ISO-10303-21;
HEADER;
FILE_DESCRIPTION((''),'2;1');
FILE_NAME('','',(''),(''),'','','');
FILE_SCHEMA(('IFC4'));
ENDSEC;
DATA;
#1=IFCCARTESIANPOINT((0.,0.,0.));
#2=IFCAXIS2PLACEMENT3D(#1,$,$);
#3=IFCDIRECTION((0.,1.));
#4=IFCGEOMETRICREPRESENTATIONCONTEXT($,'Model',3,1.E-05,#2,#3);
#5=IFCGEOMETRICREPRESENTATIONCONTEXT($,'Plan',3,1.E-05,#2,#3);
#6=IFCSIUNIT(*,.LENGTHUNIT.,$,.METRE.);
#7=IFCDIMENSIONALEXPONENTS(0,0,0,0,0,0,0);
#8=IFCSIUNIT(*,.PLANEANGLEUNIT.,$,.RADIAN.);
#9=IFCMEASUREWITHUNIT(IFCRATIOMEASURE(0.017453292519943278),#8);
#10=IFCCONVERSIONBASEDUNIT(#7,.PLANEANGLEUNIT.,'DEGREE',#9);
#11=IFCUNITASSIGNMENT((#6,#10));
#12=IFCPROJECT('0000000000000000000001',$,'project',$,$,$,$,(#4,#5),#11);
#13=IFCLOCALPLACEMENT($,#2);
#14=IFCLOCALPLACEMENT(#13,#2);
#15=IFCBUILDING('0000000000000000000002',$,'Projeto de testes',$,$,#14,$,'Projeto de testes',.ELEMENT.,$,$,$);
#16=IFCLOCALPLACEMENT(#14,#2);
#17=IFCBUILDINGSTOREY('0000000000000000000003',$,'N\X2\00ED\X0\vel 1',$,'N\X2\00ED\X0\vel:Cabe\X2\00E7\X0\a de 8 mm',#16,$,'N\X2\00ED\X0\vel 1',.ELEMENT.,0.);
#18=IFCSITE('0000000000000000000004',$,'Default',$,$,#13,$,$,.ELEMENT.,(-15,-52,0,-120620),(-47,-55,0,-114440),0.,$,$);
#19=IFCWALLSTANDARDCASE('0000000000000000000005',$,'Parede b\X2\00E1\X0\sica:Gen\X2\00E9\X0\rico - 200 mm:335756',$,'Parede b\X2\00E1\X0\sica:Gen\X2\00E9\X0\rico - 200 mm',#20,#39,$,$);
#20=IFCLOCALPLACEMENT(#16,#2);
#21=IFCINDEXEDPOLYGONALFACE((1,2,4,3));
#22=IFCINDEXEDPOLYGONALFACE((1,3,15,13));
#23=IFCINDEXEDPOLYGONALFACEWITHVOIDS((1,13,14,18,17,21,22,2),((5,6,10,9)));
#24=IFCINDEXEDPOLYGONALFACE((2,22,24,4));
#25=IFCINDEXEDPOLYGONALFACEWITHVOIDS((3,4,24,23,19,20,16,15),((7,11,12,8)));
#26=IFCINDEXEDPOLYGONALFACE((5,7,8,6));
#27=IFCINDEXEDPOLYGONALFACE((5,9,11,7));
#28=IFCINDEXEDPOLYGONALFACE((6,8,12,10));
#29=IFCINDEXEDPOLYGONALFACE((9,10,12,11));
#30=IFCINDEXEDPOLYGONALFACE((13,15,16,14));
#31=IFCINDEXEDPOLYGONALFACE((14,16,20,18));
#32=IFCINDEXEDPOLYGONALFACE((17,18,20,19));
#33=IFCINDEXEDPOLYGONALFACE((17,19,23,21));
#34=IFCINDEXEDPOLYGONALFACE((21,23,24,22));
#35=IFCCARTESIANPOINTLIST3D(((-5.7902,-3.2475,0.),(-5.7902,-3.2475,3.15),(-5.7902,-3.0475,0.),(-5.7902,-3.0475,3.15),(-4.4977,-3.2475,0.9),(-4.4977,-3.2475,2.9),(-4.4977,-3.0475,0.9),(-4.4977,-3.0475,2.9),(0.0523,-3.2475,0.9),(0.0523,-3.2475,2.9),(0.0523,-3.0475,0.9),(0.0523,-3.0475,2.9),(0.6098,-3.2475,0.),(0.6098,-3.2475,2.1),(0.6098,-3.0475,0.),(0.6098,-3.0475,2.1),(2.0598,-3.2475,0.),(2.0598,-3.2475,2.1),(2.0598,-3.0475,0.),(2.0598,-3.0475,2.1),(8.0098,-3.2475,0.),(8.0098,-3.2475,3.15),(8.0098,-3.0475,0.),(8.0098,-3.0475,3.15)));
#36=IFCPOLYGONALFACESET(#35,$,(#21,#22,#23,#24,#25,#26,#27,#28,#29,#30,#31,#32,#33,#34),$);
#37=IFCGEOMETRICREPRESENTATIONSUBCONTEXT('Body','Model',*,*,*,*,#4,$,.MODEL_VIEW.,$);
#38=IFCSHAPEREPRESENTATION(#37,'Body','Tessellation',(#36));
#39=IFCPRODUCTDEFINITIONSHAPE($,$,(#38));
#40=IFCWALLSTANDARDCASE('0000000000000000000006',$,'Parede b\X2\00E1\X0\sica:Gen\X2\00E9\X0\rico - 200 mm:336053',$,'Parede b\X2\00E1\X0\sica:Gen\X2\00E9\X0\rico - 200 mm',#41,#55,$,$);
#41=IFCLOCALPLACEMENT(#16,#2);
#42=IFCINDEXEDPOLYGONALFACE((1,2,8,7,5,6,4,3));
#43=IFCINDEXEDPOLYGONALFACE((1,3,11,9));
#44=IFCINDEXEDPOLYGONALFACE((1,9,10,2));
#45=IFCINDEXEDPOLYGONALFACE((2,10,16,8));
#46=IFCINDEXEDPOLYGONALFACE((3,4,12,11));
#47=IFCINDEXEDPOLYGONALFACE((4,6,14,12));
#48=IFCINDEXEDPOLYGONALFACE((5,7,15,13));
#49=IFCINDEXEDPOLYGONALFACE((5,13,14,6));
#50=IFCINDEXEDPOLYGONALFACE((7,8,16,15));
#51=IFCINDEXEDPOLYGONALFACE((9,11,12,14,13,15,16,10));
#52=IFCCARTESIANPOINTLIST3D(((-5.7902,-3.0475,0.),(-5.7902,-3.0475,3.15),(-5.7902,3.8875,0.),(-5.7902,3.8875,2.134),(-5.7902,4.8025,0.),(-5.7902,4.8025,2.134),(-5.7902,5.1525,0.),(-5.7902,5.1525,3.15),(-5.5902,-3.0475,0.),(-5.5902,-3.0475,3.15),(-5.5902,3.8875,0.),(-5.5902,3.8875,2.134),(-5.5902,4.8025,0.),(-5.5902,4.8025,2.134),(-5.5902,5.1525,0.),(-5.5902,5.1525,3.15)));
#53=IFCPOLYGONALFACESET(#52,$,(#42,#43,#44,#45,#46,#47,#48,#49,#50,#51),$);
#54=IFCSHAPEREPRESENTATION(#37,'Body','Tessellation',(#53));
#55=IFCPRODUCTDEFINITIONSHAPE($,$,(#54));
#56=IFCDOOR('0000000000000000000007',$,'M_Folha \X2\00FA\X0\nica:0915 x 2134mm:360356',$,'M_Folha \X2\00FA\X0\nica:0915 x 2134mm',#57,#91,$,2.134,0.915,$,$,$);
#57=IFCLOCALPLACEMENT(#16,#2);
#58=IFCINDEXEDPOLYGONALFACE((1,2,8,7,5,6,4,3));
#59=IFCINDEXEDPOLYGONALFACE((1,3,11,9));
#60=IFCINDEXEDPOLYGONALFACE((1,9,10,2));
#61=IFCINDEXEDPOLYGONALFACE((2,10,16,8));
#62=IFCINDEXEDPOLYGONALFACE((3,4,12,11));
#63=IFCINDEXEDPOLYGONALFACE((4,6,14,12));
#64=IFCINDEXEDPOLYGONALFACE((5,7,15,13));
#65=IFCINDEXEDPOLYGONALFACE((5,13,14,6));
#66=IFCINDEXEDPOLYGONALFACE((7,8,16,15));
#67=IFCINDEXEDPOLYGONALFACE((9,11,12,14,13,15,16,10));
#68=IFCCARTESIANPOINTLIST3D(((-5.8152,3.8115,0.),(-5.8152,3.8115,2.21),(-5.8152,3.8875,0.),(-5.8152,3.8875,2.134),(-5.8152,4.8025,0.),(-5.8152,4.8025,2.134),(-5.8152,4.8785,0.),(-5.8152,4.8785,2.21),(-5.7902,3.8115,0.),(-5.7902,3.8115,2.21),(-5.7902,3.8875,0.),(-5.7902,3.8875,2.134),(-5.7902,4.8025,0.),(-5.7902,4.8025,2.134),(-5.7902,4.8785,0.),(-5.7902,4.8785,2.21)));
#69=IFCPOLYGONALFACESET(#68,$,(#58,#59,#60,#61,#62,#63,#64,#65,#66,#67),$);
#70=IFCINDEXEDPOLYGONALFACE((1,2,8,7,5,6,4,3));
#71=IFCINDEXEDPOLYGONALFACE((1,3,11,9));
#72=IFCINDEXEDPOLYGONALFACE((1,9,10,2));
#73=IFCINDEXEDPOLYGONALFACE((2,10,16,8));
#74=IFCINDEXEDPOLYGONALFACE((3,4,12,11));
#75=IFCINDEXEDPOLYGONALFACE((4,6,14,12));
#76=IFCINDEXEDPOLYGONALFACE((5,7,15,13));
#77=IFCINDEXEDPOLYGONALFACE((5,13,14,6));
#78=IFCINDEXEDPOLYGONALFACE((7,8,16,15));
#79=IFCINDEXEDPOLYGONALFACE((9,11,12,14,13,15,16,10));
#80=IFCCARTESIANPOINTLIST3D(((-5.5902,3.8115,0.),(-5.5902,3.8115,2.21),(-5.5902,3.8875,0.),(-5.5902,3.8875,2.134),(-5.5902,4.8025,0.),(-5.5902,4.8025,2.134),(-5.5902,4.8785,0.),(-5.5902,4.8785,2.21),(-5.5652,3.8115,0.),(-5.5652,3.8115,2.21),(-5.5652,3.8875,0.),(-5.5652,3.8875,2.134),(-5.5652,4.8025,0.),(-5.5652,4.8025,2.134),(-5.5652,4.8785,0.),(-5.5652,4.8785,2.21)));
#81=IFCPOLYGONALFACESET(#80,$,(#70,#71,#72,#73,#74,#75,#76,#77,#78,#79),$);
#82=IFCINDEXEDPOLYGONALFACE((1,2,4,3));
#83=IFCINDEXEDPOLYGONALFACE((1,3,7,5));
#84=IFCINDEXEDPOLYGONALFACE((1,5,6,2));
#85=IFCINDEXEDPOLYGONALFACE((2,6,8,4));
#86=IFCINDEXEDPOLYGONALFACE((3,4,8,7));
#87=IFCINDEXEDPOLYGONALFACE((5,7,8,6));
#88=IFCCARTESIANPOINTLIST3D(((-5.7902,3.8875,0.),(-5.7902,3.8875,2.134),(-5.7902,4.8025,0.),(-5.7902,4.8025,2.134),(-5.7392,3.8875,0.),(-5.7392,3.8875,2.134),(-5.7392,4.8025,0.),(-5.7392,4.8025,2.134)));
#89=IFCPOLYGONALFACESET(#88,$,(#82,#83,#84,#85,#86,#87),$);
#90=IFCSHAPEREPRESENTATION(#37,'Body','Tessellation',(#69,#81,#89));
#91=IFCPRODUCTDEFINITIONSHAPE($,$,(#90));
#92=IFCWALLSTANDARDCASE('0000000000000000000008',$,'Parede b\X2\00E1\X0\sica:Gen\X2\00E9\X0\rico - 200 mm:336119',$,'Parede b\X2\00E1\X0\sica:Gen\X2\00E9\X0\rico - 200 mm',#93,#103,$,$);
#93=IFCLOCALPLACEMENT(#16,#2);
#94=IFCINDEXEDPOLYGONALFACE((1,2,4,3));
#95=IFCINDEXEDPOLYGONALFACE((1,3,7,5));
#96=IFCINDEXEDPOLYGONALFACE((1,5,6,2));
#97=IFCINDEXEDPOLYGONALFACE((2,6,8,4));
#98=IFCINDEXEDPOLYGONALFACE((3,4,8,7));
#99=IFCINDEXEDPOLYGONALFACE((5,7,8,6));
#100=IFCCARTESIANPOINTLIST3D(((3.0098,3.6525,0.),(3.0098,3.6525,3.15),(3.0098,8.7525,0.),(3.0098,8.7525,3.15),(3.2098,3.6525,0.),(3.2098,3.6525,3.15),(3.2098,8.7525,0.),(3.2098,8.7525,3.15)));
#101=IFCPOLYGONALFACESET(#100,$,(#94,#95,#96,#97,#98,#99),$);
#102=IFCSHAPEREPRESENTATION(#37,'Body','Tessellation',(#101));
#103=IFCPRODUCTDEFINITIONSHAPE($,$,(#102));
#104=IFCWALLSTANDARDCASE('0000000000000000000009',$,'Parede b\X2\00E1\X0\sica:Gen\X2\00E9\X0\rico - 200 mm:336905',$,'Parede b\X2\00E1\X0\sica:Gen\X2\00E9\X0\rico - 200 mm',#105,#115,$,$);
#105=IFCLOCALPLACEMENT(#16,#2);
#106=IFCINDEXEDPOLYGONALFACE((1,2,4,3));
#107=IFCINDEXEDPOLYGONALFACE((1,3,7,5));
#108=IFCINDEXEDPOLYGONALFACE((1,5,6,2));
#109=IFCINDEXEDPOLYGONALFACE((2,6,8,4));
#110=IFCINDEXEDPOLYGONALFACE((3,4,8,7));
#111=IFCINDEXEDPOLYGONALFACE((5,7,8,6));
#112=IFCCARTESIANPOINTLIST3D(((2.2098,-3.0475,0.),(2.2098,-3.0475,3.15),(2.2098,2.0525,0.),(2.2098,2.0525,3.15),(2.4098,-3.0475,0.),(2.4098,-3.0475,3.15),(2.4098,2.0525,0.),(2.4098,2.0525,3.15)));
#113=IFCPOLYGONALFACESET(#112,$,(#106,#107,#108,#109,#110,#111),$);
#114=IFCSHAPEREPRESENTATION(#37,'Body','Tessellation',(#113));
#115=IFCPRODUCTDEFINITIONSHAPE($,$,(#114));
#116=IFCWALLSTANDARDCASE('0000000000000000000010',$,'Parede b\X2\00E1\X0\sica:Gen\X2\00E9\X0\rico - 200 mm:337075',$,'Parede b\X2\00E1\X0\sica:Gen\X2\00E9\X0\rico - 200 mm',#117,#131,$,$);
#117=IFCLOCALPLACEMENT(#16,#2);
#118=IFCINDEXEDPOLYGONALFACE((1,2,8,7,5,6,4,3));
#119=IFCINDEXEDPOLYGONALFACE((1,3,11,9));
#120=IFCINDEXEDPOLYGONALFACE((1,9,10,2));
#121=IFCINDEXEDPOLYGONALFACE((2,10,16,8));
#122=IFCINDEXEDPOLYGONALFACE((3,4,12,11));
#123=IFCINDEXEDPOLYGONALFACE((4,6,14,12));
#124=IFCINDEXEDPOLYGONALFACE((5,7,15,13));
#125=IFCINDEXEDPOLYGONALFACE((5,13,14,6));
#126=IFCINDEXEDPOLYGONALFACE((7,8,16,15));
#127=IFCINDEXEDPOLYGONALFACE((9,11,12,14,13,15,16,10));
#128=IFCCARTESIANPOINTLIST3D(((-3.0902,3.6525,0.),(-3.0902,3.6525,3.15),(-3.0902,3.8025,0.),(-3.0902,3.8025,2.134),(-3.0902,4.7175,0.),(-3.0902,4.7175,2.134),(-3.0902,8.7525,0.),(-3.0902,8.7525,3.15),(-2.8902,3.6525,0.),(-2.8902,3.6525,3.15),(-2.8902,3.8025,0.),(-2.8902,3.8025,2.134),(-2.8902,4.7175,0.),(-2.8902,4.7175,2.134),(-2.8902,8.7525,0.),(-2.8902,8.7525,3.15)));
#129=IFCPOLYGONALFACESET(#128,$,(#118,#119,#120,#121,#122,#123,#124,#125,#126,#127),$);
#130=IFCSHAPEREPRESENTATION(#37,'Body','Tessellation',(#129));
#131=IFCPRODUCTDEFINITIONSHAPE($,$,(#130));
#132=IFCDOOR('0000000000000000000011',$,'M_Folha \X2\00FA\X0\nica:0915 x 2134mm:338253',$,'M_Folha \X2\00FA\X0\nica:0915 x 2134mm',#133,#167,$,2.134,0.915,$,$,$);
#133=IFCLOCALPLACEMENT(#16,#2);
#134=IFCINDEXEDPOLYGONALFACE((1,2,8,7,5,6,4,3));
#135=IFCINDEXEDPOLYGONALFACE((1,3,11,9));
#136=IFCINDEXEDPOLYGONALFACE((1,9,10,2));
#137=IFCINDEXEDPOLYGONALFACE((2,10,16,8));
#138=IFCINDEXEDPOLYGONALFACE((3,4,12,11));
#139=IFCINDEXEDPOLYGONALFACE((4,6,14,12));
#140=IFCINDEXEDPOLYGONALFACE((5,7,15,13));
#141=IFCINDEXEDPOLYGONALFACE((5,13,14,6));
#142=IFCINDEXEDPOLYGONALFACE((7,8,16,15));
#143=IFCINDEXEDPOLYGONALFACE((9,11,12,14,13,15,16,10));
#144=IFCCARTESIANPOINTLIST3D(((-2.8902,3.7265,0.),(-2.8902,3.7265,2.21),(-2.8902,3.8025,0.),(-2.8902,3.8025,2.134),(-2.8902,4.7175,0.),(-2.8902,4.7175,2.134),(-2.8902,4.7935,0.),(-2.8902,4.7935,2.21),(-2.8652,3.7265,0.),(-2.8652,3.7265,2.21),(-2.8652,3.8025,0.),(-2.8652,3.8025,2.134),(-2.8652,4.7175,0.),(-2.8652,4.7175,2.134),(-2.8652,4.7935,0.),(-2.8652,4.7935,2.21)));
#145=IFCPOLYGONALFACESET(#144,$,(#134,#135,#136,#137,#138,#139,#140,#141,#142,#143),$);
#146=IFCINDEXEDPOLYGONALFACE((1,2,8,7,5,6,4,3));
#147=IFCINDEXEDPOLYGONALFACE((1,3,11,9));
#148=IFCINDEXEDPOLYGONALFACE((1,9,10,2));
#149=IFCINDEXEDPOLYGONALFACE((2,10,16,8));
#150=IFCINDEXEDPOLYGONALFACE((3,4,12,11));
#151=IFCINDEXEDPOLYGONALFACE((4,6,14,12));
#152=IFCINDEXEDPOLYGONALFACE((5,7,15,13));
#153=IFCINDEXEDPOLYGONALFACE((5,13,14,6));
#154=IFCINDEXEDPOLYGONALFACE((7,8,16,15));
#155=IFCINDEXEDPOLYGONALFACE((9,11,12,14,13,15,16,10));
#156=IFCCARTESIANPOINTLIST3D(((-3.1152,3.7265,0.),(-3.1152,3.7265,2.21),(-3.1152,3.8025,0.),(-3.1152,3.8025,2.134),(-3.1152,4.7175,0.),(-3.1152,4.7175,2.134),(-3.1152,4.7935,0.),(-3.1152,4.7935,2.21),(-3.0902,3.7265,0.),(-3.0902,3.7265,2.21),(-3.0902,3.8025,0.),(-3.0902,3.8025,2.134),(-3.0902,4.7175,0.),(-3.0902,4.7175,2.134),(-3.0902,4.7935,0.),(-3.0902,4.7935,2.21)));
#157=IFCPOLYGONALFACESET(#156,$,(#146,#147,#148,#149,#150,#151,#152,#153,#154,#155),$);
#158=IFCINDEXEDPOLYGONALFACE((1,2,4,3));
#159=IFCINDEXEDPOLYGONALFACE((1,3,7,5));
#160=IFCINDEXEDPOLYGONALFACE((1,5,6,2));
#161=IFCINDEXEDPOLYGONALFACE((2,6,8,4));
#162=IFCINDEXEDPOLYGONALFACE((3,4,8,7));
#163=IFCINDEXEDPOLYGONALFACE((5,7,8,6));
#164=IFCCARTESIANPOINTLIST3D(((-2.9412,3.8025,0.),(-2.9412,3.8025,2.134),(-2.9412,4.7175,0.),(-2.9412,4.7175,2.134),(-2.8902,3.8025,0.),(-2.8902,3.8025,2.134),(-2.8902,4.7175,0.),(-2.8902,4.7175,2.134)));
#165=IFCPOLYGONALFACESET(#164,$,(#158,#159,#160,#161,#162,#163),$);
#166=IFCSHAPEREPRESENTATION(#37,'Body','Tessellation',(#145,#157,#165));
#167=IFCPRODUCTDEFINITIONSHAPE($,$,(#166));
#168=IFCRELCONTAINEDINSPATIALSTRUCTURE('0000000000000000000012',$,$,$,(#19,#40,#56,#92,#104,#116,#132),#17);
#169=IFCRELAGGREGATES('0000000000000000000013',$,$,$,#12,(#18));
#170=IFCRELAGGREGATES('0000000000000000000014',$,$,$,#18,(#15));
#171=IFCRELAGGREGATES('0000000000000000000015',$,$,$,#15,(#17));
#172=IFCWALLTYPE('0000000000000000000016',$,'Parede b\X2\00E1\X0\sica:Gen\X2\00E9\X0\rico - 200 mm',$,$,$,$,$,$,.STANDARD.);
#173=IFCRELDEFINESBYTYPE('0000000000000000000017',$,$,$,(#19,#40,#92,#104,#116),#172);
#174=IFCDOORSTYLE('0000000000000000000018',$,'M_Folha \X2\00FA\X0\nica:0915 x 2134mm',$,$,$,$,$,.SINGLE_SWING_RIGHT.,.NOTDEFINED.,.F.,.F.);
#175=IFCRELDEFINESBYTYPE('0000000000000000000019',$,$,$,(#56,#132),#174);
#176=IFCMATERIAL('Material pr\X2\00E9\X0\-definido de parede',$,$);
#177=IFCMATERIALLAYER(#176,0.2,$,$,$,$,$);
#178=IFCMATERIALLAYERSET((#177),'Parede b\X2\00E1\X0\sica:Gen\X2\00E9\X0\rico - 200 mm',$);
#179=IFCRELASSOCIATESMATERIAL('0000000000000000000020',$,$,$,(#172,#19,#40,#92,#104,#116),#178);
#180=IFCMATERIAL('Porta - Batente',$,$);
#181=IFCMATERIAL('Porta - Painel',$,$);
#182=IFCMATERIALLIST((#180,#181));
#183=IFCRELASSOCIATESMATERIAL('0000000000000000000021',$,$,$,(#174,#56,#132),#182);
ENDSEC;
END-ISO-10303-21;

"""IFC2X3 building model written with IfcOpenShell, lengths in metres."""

from ifc_helpers import new_model, entity, si_unit, converted_unit, direction, frame, frame_2d, origin, place, context, subcontext, project, spatial, polyline, rectangle, outline, extrude, source, transform, mapped, material, material_list, layer, layer_set, layer_usage, type_object, type_shapes, element, fill, save


model = new_model("IFC2X3")

# Units and contexts
model_context = context("Model", 3, precision=1e-05, world=origin(), true_north=direction((0.0, 1.0)))
plan_context = context("Plan", 3, precision=1e-05, world=origin(), true_north=direction((0.0, 1.0)))
body_context = subcontext(model_context, "Body", "Model", "MODEL_VIEW")
ifc_project = project(units=[si_unit("LENGTHUNIT", "METRE"), converted_unit("PLANEANGLEUNIT", "DEGREE", entity("IfcRatioMeasure", 0.017453292519943278), si_unit("PLANEANGLEUNIT", "RADIAN"), dimensions=[0, 0, 0, 0, 0, 0, 0])], contexts=[model_context, plan_context])

# Site, building, storey
site_placement = place(None, origin())
site = spatial("IfcSite", under=ifc_project, at=site_placement, Name="Default", CompositionType="ELEMENT", RefLatitude=(-15, -52, 0, -120620), RefLongitude=(-47, -55, 0, -114440), RefElevation=0.0)
building_placement = place(site_placement, origin())
building = spatial("IfcBuilding", under=site, at=building_placement, Name="Projeto de testes", LongName="Projeto de testes", CompositionType="ELEMENT")
storey_placement = place(building_placement, origin())
storey = spatial("IfcBuildingStorey", under=building, at=storey_placement, Name="Nível 1", ObjectType="Nível:Cabeça de 8 mm", LongName="Nível 1", CompositionType="ELEMENT", Elevation=0.0)

# Wall, openings
ifc_material_1 = material(Name="Material pré-definido de parede")
ifc_layer_1 = layer(ifc_material_1, 0.2)
ifc_layer_set_1 = layer_set([ifc_layer_1], Name="Parede básica:Genérico - 200 mm")
ifc_layer_usage_1 = layer_usage(ifc_layer_set_1, "AXIS2", "POSITIVE", -0.1)
wall_type = type_object("IfcWallType", Name="Parede básica:Genérico - 200 mm", PredefinedType="STANDARD", material=ifc_layer_set_1)
wall_1_placement = place(storey_placement, frame((-5.7902, -3.1475, 0.0)))
wall_1 = element("IfcWallStandardCase", 1, at=wall_1_placement, inside=storey, type_object=wall_type, material=ifc_layer_usage_1, Name="Parede básica:Genérico - 200 mm:335756", ObjectType="Parede básica:Genérico - 200 mm", context=body_context, shape_type="SweptSolid", body=[
    extrude(rectangle(XDim=13.8, YDim=0.2, at=frame_2d((6.9, 0.0), x_axis=(-1.0, 0.0))), origin(), (0.0, 0.0, 1.0), 3.15),
])
opening_1_placement = place(wall_1_placement, frame((6.4, -0.1, 0.0)))
element("IfcOpeningElement", 2, at=opening_1_placement, cuts=wall_1, ObjectType="Opening", context=body_context, shape_type="SweptSolid", body=[
    extrude(rectangle(XDim=2.1, YDim=1.45, at=frame_2d((1.05, 0.725), x_axis=(1.0, 0.0))), frame((0.0, 0.0, 0.0), z_axis=(0.0, 1.0, 0.0), x_axis=(0.0, 0.0, 1.0)), (0.0, 0.0, 1.0), 0.2),
])
opening_2_placement = place(wall_1_placement, frame((5.8425, 0.1, 0.9)))
element("IfcOpeningElement", 3, at=opening_2_placement, cuts=wall_1, ObjectType="Opening", context=body_context, shape_type="SweptSolid", body=[
    extrude(rectangle(XDim=2.0, YDim=4.55, at=frame_2d((1.0, 2.275), x_axis=(-1.0, 0.0))), frame((0.0, 0.0, 0.0), z_axis=(0.0, -1.0, 0.0), x_axis=(0.0, 0.0, 1.0)), (0.0, 0.0, 1.0), 0.2),
])

# Wall, opening, door
ifc_layer_usage_2 = layer_usage(ifc_layer_set_1, "AXIS2", "NEGATIVE", 0.1)
wall_2_placement = place(storey_placement, frame((-5.6902, 5.1525, 0.0), z_axis=(0.0, 0.0, 1.0), x_axis=(0.0, -1.0, 0.0)))
wall_2 = element("IfcWallStandardCase", 4, at=wall_2_placement, inside=storey, type_object=wall_type, material=ifc_layer_usage_2, Name="Parede básica:Genérico - 200 mm:336053", ObjectType="Parede básica:Genérico - 200 mm", context=body_context, shape_type="SweptSolid", body=[
    extrude(rectangle(XDim=8.2, YDim=0.2, at=frame_2d((4.1, 0.0), x_axis=(1.0, 0.0))), origin(), (0.0, 0.0, 1.0), 3.15),
])
opening_3_placement = place(wall_2_placement, frame((1.265, 0.1, 0.0)))
opening_3 = element("IfcOpeningElement", 5, at=opening_3_placement, cuts=wall_2, ObjectType="Opening", context=body_context, shape_type="SweptSolid", body=[
    extrude(rectangle(XDim=0.915, YDim=2.134, at=frame_2d((1.067, 0.4575), x_axis=(0.0, 1.0))), frame((0.0, 0.0, 0.0), z_axis=(0.0, -1.0, 0.0), x_axis=(0.0, 0.0, 1.0)), (0.0, 0.0, 1.0), 0.2),
])
ifc_material_2 = material(Name="Porta - Batente")
ifc_material_3 = material(Name="Porta - Painel")
ifc_material_list_1 = material_list([ifc_material_2, ifc_material_3])
door_style_1 = type_object("IfcDoorStyle", Name="M_Folha única:0915 x 2134mm", ConstructionType="NOTDEFINED", OperationType="SINGLE_SWING_RIGHT", ParameterTakesPrecedence=False, Sizeable=False, material=ifc_material_list_1)
shared_shape_1 = source(origin(), body_context, "Body", "SweptSolid", [
    extrude(outline(polyline([(-0.5335, -1.124), (0.5335, -1.124), (0.5335, 1.086), (0.4575, 1.086), (0.4575, -1.048), (-0.4575, -1.048), (-0.4575, 1.086), (-0.5335, 1.086), (-0.5335, -1.124)])), frame((0.4575, 0.2, 1.086), z_axis=(0.0, 1.0, 0.0), x_axis=(1.0, 0.0, 0.0)), (0.0, 0.0, 1.0), 0.025),
    extrude(outline(polyline([(-1.124, -0.5335), (1.086, -0.5335), (1.086, -0.4575), (-1.048, -0.4575), (-1.048, 0.4575), (1.086, 0.4575), (1.086, 0.5335), (-1.124, 0.5335), (-1.124, -0.5335)])), frame((0.4575, -0.025, 1.086), z_axis=(0.0, 1.0, 0.0), x_axis=(0.0, 0.0, -1.0)), (0.0, 0.0, 1.0), 0.025),
    extrude(rectangle(XDim=0.051, YDim=0.915, at=frame_2d((0.0, 0.0), x_axis=(1.0, 0.0))), frame((0.4575, 0.1745, 0.0), z_axis=(0.0, 0.0, 1.0), x_axis=(0.0, 1.0, 0.0)), (0.0, 0.0, 1.0), 2.134),
])
type_shapes(door_style_1, [shared_shape_1])
door_1_placement = place(opening_3_placement, frame((0.0, 0.0, 0.0), z_axis=(0.0, 0.0, 1.0), x_axis=(-1.0, 0.0, 0.0)))
door_1 = element("IfcDoor", 6, at=door_1_placement, inside=storey, type_object=door_style_1, material=ifc_material_list_1, Name="M_Folha única:0915 x 2134mm:360356", ObjectType="M_Folha única:0915 x 2134mm", OverallHeight=2.134, OverallWidth=0.915, context=body_context, shape_type="MappedRepresentation", body=[
    mapped(shared_shape_1, transform((0.0, 0.0, 0.0), scale=1.0)),
])
fill(opening_3, door_1)

# Walls
wall_3_placement = place(storey_placement, frame((3.1098, 8.7525, 0.0), z_axis=(0.0, 0.0, 1.0), x_axis=(0.0, -1.0, 0.0)))
element("IfcWallStandardCase", 7, at=wall_3_placement, inside=storey, type_object=wall_type, material=ifc_layer_usage_2, Name="Parede básica:Genérico - 200 mm:336119", ObjectType="Parede básica:Genérico - 200 mm", context=body_context, shape_type="SweptSolid", body=[
    extrude(rectangle(XDim=5.1, YDim=0.2, at=frame_2d((2.55, 0.0), x_axis=(-1.0, 0.0))), origin(), (0.0, 0.0, 1.0), 3.15),
])
wall_4_placement = place(storey_placement, frame((2.3098, 2.0525, 0.0), z_axis=(0.0, 0.0, 1.0), x_axis=(0.0, -1.0, 0.0)))
element("IfcWallStandardCase", 8, at=wall_4_placement, inside=storey, type_object=wall_type, material=ifc_layer_usage_2, Name="Parede básica:Genérico - 200 mm:336905", ObjectType="Parede básica:Genérico - 200 mm", context=body_context, shape_type="SweptSolid", body=[
    extrude(rectangle(XDim=5.1, YDim=0.2, at=frame_2d((2.55, 0.0), x_axis=(-1.0, 0.0))), origin(), (0.0, 0.0, 1.0), 3.15),
])

# Wall, opening, door
wall_5_placement = place(storey_placement, frame((-2.9902, 8.7525, 0.0), z_axis=(0.0, 0.0, 1.0), x_axis=(0.0, -1.0, 0.0)))
wall_5 = element("IfcWallStandardCase", 9, at=wall_5_placement, inside=storey, type_object=wall_type, material=ifc_layer_usage_2, Name="Parede básica:Genérico - 200 mm:337075", ObjectType="Parede básica:Genérico - 200 mm", context=body_context, shape_type="SweptSolid", body=[
    extrude(rectangle(XDim=5.1, YDim=0.2, at=frame_2d((2.55, 0.0), x_axis=(-1.0, 0.0))), origin(), (0.0, 0.0, 1.0), 3.15),
])
opening_4_placement = place(wall_5_placement, frame((4.035, -0.1, 0.0)))
opening_4 = element("IfcOpeningElement", 10, at=opening_4_placement, cuts=wall_5, ObjectType="Opening", context=body_context, shape_type="SweptSolid", body=[
    extrude(rectangle(XDim=0.915, YDim=2.134, at=frame_2d((1.067, 0.4575), x_axis=(0.0, 1.0))), frame((0.0, 0.0, 0.0), z_axis=(0.0, 1.0, 0.0), x_axis=(0.0, 0.0, 1.0)), (0.0, 0.0, 1.0), 0.2),
])
door_2_placement = place(opening_4_placement, origin())
door_2 = element("IfcDoor", 11, at=door_2_placement, inside=storey, type_object=door_style_1, material=ifc_material_list_1, Name="M_Folha única:0915 x 2134mm:338253", ObjectType="M_Folha única:0915 x 2134mm", OverallHeight=2.134, OverallWidth=0.915, context=body_context, shape_type="MappedRepresentation", body=[
    mapped(shared_shape_1, transform((0.0, 0.0, 0.0), scale=1.0)),
])
fill(opening_4, door_2)

save(model, "model.ifc")
